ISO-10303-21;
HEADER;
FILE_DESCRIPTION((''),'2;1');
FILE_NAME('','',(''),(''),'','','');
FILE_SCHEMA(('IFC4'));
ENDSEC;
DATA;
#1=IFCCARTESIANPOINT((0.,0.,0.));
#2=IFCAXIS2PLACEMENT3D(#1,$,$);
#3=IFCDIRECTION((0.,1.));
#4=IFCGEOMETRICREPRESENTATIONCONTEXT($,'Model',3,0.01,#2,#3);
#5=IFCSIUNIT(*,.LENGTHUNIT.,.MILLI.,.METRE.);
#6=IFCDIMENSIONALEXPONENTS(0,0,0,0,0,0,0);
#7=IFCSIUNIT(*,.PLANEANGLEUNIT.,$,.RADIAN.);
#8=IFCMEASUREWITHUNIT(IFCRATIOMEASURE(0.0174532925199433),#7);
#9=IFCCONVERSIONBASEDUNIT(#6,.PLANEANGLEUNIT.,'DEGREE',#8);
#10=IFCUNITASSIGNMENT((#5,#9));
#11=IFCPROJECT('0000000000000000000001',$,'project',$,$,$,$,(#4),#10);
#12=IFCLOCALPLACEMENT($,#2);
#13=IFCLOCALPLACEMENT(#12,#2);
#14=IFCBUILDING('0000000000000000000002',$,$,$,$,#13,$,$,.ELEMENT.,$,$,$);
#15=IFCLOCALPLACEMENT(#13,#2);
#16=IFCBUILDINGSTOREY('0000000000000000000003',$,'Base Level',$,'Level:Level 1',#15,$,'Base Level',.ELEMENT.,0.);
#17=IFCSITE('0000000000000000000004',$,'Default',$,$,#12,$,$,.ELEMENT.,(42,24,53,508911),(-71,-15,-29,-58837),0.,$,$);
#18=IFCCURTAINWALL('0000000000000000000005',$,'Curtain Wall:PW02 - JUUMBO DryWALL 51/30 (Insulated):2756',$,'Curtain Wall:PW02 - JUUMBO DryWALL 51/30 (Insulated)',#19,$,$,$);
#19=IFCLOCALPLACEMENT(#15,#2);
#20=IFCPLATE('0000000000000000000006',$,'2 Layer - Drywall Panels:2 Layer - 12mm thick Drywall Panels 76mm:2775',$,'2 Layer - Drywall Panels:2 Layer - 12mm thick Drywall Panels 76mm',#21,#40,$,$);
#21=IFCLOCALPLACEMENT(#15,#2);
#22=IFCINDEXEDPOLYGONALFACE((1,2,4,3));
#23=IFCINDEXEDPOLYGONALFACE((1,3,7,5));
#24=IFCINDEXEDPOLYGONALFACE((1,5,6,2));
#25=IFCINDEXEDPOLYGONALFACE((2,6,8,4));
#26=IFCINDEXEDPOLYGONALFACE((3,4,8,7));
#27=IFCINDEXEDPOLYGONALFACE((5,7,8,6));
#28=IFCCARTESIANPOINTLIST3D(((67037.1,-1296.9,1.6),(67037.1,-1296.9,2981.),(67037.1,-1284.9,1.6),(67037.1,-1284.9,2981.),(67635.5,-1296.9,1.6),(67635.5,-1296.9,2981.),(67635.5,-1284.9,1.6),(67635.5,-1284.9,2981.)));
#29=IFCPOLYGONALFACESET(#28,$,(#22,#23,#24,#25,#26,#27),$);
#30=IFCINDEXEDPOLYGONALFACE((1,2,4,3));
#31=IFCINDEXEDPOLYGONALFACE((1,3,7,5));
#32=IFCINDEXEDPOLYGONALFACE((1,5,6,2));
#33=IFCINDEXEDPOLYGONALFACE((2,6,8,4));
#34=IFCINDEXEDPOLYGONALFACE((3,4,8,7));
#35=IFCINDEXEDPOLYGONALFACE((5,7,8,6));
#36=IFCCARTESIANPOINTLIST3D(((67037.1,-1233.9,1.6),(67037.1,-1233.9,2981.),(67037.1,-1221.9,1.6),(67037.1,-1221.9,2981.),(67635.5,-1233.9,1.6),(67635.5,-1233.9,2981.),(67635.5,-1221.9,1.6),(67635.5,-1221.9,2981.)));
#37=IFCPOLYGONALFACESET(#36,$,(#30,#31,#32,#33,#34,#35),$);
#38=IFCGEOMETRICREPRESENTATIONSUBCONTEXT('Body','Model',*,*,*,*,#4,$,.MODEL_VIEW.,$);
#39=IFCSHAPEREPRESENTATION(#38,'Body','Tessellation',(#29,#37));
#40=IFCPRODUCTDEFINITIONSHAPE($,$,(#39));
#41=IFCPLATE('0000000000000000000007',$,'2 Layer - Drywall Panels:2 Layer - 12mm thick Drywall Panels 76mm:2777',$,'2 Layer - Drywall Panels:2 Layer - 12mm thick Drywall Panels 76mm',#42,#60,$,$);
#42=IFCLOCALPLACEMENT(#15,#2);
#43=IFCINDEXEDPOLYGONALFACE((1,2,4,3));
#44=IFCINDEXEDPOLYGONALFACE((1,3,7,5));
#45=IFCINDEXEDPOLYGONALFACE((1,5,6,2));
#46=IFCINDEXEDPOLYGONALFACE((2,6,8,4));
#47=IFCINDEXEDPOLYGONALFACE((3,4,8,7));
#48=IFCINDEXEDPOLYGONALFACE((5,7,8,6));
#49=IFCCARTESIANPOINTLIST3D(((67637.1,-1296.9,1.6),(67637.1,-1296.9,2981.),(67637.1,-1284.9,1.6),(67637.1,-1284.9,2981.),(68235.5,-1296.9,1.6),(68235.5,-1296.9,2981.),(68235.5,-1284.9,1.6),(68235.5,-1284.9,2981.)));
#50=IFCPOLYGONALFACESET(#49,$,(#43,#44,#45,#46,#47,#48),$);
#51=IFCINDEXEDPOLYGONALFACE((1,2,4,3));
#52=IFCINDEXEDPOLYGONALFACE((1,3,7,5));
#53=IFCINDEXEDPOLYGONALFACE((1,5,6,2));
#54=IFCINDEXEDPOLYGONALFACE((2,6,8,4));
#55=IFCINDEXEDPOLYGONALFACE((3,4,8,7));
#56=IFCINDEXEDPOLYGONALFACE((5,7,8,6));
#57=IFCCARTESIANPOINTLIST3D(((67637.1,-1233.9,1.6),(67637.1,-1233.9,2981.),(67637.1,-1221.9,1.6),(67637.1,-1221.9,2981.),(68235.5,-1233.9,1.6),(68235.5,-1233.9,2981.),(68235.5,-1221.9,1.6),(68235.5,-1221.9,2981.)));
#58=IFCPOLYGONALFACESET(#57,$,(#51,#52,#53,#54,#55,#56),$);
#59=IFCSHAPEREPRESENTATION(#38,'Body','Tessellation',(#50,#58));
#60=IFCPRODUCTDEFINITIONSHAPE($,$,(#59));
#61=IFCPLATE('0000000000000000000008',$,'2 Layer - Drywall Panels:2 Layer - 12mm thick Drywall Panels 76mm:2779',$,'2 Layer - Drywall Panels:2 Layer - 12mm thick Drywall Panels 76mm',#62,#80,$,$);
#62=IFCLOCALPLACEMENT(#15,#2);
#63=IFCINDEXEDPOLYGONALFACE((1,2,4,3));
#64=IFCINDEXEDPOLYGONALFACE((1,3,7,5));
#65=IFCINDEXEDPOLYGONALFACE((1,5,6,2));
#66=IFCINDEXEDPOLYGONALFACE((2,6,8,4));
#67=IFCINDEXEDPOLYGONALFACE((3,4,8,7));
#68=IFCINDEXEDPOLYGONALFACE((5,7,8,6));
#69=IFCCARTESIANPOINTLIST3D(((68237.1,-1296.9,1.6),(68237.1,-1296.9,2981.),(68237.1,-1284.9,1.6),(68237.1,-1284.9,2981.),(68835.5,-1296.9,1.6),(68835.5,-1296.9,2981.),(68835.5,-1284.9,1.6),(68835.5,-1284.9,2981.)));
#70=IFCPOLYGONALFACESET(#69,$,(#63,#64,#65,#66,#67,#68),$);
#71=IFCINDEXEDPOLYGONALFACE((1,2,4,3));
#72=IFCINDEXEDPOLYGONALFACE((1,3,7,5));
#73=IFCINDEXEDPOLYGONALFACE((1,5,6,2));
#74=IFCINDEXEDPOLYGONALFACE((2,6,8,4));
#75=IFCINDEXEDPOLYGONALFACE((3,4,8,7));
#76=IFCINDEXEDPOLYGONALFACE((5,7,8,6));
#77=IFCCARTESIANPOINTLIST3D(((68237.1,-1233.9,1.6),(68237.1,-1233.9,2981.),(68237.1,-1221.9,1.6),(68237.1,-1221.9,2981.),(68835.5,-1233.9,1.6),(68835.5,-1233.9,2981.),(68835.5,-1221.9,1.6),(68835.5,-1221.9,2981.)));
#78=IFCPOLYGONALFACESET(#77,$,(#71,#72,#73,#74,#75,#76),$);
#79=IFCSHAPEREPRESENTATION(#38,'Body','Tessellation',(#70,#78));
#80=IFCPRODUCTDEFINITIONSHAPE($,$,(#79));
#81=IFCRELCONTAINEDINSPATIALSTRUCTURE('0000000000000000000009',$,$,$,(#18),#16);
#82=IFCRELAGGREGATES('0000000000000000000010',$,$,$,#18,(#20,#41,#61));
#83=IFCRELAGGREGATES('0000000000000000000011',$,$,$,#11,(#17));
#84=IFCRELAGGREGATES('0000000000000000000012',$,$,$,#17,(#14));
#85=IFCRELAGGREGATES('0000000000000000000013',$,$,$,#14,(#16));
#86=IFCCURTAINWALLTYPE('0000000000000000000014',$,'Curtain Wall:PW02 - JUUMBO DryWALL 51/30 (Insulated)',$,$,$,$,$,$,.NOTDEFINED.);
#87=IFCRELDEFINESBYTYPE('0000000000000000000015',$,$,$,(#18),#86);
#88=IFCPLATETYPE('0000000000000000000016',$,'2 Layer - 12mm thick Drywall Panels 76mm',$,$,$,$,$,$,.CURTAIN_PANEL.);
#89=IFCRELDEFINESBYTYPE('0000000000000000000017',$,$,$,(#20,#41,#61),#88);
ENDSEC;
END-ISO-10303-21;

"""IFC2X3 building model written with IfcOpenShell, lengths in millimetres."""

from ifc_helpers import new_model, entity, si_unit, converted_unit, direction, frame, frame_2d, origin, origin_2d_with_axis, place, context, subcontext, project, spatial, rectangle, extrude, source, transform, mapped, type_object, type_shapes, element, aggregate, save


model = new_model("IFC2X3")

# Units and contexts
model_context = context("Model", 3, precision=0.01, world=origin(), true_north=direction((0.0, 1.0)))
body_context = subcontext(model_context, "Body", "Model", "MODEL_VIEW")
ifc_project = project(units=[si_unit("LENGTHUNIT", "METRE", prefix="MILLI"), converted_unit("PLANEANGLEUNIT", "DEGREE", entity("IfcRatioMeasure", 0.0174532925199433), si_unit("PLANEANGLEUNIT", "RADIAN"), dimensions=[0, 0, 0, 0, 0, 0, 0])], contexts=[model_context])

# Site, building, storey
site_placement = place(None, origin())
site = spatial("IfcSite", under=ifc_project, at=site_placement, Name="Default", CompositionType="ELEMENT", RefLatitude=(42, 24, 53, 508911), RefLongitude=(-71, -15, -29, -58837), RefElevation=0.0)
building_placement = place(site_placement, origin())
building = spatial("IfcBuilding", under=site, at=building_placement, CompositionType="ELEMENT")
storey_placement = place(building_placement, origin())
storey = spatial("IfcBuildingStorey", under=building, at=storey_placement, Name="Base Level", ObjectType="Level:Level 1", LongName="Base Level", CompositionType="ELEMENT", Elevation=0.0)

# Curtain wall, plates
curtain_wall_type = type_object("IfcCurtainWallType", Name="Curtain Wall:PW02 - JUUMBO DryWALL 51/30 (Insulated)", PredefinedType="NOTDEFINED")
curtain_wall_placement = place(building_placement, origin())
curtain_wall = element("IfcCurtainWall", 1, at=curtain_wall_placement, inside=storey, type_object=curtain_wall_type, Name="Curtain Wall:PW02 - JUUMBO DryWALL 51/30 (Insulated):2756", ObjectType="Curtain Wall:PW02 - JUUMBO DryWALL 51/30 (Insulated)")
plate_type = type_object("IfcPlateType", Name="2 Layer - 12mm thick Drywall Panels 76mm", PredefinedType="CURTAIN_PANEL")
shared_shape_1 = source(origin(), body_context, "Body", "SweptSolid", [
    extrude(rectangle(XDim=598.4, YDim=12.0, at=origin_2d_with_axis()), frame((0.0, -31.5, 0.0), z_axis=(0.0, 0.0, 1.0), x_axis=(-1.0, 0.0, 0.0)), (0.0, 0.0, 1.0), 2979.4),
    extrude(rectangle(XDim=12.0, YDim=598.4, at=frame_2d((0.0, 0.0), x_axis=(1.0, 0.0))), frame((0.0, 31.5, 0.0), z_axis=(0.0, 0.0, 1.0), x_axis=(0.0, 1.0, 0.0)), (0.0, 0.0, 1.0), 2979.4),
])
type_shapes(plate_type, [shared_shape_1])
plate_1_placement = place(curtain_wall_placement, frame((67336.3, -1259.4, 1.6)))
plate_1 = element("IfcPlate", 2, at=plate_1_placement, type_object=plate_type, Name="2 Layer - Drywall Panels:2 Layer - 12mm thick Drywall Panels 76mm:2775", ObjectType="2 Layer - Drywall Panels:2 Layer - 12mm thick Drywall Panels 76mm", context=body_context, shape_type="MappedRepresentation", body=[
    mapped(shared_shape_1, transform((0.0, 0.0, 0.0), scale=1.0)),
])
plate_2_placement = place(curtain_wall_placement, frame((67936.3, -1259.4, 1.6)))
plate_2 = element("IfcPlate", 3, at=plate_2_placement, type_object=plate_type, Name="2 Layer - Drywall Panels:2 Layer - 12mm thick Drywall Panels 76mm:2777", ObjectType="2 Layer - Drywall Panels:2 Layer - 12mm thick Drywall Panels 76mm", context=body_context, shape_type="MappedRepresentation", body=[
    mapped(shared_shape_1, transform((0.0, 0.0, 0.0), scale=1.0)),
])
plate_3_placement = place(curtain_wall_placement, frame((68536.3, -1259.4, 1.6)))
plate_3 = element("IfcPlate", 4, at=plate_3_placement, type_object=plate_type, Name="2 Layer - Drywall Panels:2 Layer - 12mm thick Drywall Panels 76mm:2779", ObjectType="2 Layer - Drywall Panels:2 Layer - 12mm thick Drywall Panels 76mm", context=body_context, shape_type="MappedRepresentation", body=[
    mapped(shared_shape_1, transform((0.0, 0.0, 0.0), scale=1.0)),
])
aggregate(curtain_wall, [plate_1, plate_2, plate_3])

save(model, "model.ifc")
